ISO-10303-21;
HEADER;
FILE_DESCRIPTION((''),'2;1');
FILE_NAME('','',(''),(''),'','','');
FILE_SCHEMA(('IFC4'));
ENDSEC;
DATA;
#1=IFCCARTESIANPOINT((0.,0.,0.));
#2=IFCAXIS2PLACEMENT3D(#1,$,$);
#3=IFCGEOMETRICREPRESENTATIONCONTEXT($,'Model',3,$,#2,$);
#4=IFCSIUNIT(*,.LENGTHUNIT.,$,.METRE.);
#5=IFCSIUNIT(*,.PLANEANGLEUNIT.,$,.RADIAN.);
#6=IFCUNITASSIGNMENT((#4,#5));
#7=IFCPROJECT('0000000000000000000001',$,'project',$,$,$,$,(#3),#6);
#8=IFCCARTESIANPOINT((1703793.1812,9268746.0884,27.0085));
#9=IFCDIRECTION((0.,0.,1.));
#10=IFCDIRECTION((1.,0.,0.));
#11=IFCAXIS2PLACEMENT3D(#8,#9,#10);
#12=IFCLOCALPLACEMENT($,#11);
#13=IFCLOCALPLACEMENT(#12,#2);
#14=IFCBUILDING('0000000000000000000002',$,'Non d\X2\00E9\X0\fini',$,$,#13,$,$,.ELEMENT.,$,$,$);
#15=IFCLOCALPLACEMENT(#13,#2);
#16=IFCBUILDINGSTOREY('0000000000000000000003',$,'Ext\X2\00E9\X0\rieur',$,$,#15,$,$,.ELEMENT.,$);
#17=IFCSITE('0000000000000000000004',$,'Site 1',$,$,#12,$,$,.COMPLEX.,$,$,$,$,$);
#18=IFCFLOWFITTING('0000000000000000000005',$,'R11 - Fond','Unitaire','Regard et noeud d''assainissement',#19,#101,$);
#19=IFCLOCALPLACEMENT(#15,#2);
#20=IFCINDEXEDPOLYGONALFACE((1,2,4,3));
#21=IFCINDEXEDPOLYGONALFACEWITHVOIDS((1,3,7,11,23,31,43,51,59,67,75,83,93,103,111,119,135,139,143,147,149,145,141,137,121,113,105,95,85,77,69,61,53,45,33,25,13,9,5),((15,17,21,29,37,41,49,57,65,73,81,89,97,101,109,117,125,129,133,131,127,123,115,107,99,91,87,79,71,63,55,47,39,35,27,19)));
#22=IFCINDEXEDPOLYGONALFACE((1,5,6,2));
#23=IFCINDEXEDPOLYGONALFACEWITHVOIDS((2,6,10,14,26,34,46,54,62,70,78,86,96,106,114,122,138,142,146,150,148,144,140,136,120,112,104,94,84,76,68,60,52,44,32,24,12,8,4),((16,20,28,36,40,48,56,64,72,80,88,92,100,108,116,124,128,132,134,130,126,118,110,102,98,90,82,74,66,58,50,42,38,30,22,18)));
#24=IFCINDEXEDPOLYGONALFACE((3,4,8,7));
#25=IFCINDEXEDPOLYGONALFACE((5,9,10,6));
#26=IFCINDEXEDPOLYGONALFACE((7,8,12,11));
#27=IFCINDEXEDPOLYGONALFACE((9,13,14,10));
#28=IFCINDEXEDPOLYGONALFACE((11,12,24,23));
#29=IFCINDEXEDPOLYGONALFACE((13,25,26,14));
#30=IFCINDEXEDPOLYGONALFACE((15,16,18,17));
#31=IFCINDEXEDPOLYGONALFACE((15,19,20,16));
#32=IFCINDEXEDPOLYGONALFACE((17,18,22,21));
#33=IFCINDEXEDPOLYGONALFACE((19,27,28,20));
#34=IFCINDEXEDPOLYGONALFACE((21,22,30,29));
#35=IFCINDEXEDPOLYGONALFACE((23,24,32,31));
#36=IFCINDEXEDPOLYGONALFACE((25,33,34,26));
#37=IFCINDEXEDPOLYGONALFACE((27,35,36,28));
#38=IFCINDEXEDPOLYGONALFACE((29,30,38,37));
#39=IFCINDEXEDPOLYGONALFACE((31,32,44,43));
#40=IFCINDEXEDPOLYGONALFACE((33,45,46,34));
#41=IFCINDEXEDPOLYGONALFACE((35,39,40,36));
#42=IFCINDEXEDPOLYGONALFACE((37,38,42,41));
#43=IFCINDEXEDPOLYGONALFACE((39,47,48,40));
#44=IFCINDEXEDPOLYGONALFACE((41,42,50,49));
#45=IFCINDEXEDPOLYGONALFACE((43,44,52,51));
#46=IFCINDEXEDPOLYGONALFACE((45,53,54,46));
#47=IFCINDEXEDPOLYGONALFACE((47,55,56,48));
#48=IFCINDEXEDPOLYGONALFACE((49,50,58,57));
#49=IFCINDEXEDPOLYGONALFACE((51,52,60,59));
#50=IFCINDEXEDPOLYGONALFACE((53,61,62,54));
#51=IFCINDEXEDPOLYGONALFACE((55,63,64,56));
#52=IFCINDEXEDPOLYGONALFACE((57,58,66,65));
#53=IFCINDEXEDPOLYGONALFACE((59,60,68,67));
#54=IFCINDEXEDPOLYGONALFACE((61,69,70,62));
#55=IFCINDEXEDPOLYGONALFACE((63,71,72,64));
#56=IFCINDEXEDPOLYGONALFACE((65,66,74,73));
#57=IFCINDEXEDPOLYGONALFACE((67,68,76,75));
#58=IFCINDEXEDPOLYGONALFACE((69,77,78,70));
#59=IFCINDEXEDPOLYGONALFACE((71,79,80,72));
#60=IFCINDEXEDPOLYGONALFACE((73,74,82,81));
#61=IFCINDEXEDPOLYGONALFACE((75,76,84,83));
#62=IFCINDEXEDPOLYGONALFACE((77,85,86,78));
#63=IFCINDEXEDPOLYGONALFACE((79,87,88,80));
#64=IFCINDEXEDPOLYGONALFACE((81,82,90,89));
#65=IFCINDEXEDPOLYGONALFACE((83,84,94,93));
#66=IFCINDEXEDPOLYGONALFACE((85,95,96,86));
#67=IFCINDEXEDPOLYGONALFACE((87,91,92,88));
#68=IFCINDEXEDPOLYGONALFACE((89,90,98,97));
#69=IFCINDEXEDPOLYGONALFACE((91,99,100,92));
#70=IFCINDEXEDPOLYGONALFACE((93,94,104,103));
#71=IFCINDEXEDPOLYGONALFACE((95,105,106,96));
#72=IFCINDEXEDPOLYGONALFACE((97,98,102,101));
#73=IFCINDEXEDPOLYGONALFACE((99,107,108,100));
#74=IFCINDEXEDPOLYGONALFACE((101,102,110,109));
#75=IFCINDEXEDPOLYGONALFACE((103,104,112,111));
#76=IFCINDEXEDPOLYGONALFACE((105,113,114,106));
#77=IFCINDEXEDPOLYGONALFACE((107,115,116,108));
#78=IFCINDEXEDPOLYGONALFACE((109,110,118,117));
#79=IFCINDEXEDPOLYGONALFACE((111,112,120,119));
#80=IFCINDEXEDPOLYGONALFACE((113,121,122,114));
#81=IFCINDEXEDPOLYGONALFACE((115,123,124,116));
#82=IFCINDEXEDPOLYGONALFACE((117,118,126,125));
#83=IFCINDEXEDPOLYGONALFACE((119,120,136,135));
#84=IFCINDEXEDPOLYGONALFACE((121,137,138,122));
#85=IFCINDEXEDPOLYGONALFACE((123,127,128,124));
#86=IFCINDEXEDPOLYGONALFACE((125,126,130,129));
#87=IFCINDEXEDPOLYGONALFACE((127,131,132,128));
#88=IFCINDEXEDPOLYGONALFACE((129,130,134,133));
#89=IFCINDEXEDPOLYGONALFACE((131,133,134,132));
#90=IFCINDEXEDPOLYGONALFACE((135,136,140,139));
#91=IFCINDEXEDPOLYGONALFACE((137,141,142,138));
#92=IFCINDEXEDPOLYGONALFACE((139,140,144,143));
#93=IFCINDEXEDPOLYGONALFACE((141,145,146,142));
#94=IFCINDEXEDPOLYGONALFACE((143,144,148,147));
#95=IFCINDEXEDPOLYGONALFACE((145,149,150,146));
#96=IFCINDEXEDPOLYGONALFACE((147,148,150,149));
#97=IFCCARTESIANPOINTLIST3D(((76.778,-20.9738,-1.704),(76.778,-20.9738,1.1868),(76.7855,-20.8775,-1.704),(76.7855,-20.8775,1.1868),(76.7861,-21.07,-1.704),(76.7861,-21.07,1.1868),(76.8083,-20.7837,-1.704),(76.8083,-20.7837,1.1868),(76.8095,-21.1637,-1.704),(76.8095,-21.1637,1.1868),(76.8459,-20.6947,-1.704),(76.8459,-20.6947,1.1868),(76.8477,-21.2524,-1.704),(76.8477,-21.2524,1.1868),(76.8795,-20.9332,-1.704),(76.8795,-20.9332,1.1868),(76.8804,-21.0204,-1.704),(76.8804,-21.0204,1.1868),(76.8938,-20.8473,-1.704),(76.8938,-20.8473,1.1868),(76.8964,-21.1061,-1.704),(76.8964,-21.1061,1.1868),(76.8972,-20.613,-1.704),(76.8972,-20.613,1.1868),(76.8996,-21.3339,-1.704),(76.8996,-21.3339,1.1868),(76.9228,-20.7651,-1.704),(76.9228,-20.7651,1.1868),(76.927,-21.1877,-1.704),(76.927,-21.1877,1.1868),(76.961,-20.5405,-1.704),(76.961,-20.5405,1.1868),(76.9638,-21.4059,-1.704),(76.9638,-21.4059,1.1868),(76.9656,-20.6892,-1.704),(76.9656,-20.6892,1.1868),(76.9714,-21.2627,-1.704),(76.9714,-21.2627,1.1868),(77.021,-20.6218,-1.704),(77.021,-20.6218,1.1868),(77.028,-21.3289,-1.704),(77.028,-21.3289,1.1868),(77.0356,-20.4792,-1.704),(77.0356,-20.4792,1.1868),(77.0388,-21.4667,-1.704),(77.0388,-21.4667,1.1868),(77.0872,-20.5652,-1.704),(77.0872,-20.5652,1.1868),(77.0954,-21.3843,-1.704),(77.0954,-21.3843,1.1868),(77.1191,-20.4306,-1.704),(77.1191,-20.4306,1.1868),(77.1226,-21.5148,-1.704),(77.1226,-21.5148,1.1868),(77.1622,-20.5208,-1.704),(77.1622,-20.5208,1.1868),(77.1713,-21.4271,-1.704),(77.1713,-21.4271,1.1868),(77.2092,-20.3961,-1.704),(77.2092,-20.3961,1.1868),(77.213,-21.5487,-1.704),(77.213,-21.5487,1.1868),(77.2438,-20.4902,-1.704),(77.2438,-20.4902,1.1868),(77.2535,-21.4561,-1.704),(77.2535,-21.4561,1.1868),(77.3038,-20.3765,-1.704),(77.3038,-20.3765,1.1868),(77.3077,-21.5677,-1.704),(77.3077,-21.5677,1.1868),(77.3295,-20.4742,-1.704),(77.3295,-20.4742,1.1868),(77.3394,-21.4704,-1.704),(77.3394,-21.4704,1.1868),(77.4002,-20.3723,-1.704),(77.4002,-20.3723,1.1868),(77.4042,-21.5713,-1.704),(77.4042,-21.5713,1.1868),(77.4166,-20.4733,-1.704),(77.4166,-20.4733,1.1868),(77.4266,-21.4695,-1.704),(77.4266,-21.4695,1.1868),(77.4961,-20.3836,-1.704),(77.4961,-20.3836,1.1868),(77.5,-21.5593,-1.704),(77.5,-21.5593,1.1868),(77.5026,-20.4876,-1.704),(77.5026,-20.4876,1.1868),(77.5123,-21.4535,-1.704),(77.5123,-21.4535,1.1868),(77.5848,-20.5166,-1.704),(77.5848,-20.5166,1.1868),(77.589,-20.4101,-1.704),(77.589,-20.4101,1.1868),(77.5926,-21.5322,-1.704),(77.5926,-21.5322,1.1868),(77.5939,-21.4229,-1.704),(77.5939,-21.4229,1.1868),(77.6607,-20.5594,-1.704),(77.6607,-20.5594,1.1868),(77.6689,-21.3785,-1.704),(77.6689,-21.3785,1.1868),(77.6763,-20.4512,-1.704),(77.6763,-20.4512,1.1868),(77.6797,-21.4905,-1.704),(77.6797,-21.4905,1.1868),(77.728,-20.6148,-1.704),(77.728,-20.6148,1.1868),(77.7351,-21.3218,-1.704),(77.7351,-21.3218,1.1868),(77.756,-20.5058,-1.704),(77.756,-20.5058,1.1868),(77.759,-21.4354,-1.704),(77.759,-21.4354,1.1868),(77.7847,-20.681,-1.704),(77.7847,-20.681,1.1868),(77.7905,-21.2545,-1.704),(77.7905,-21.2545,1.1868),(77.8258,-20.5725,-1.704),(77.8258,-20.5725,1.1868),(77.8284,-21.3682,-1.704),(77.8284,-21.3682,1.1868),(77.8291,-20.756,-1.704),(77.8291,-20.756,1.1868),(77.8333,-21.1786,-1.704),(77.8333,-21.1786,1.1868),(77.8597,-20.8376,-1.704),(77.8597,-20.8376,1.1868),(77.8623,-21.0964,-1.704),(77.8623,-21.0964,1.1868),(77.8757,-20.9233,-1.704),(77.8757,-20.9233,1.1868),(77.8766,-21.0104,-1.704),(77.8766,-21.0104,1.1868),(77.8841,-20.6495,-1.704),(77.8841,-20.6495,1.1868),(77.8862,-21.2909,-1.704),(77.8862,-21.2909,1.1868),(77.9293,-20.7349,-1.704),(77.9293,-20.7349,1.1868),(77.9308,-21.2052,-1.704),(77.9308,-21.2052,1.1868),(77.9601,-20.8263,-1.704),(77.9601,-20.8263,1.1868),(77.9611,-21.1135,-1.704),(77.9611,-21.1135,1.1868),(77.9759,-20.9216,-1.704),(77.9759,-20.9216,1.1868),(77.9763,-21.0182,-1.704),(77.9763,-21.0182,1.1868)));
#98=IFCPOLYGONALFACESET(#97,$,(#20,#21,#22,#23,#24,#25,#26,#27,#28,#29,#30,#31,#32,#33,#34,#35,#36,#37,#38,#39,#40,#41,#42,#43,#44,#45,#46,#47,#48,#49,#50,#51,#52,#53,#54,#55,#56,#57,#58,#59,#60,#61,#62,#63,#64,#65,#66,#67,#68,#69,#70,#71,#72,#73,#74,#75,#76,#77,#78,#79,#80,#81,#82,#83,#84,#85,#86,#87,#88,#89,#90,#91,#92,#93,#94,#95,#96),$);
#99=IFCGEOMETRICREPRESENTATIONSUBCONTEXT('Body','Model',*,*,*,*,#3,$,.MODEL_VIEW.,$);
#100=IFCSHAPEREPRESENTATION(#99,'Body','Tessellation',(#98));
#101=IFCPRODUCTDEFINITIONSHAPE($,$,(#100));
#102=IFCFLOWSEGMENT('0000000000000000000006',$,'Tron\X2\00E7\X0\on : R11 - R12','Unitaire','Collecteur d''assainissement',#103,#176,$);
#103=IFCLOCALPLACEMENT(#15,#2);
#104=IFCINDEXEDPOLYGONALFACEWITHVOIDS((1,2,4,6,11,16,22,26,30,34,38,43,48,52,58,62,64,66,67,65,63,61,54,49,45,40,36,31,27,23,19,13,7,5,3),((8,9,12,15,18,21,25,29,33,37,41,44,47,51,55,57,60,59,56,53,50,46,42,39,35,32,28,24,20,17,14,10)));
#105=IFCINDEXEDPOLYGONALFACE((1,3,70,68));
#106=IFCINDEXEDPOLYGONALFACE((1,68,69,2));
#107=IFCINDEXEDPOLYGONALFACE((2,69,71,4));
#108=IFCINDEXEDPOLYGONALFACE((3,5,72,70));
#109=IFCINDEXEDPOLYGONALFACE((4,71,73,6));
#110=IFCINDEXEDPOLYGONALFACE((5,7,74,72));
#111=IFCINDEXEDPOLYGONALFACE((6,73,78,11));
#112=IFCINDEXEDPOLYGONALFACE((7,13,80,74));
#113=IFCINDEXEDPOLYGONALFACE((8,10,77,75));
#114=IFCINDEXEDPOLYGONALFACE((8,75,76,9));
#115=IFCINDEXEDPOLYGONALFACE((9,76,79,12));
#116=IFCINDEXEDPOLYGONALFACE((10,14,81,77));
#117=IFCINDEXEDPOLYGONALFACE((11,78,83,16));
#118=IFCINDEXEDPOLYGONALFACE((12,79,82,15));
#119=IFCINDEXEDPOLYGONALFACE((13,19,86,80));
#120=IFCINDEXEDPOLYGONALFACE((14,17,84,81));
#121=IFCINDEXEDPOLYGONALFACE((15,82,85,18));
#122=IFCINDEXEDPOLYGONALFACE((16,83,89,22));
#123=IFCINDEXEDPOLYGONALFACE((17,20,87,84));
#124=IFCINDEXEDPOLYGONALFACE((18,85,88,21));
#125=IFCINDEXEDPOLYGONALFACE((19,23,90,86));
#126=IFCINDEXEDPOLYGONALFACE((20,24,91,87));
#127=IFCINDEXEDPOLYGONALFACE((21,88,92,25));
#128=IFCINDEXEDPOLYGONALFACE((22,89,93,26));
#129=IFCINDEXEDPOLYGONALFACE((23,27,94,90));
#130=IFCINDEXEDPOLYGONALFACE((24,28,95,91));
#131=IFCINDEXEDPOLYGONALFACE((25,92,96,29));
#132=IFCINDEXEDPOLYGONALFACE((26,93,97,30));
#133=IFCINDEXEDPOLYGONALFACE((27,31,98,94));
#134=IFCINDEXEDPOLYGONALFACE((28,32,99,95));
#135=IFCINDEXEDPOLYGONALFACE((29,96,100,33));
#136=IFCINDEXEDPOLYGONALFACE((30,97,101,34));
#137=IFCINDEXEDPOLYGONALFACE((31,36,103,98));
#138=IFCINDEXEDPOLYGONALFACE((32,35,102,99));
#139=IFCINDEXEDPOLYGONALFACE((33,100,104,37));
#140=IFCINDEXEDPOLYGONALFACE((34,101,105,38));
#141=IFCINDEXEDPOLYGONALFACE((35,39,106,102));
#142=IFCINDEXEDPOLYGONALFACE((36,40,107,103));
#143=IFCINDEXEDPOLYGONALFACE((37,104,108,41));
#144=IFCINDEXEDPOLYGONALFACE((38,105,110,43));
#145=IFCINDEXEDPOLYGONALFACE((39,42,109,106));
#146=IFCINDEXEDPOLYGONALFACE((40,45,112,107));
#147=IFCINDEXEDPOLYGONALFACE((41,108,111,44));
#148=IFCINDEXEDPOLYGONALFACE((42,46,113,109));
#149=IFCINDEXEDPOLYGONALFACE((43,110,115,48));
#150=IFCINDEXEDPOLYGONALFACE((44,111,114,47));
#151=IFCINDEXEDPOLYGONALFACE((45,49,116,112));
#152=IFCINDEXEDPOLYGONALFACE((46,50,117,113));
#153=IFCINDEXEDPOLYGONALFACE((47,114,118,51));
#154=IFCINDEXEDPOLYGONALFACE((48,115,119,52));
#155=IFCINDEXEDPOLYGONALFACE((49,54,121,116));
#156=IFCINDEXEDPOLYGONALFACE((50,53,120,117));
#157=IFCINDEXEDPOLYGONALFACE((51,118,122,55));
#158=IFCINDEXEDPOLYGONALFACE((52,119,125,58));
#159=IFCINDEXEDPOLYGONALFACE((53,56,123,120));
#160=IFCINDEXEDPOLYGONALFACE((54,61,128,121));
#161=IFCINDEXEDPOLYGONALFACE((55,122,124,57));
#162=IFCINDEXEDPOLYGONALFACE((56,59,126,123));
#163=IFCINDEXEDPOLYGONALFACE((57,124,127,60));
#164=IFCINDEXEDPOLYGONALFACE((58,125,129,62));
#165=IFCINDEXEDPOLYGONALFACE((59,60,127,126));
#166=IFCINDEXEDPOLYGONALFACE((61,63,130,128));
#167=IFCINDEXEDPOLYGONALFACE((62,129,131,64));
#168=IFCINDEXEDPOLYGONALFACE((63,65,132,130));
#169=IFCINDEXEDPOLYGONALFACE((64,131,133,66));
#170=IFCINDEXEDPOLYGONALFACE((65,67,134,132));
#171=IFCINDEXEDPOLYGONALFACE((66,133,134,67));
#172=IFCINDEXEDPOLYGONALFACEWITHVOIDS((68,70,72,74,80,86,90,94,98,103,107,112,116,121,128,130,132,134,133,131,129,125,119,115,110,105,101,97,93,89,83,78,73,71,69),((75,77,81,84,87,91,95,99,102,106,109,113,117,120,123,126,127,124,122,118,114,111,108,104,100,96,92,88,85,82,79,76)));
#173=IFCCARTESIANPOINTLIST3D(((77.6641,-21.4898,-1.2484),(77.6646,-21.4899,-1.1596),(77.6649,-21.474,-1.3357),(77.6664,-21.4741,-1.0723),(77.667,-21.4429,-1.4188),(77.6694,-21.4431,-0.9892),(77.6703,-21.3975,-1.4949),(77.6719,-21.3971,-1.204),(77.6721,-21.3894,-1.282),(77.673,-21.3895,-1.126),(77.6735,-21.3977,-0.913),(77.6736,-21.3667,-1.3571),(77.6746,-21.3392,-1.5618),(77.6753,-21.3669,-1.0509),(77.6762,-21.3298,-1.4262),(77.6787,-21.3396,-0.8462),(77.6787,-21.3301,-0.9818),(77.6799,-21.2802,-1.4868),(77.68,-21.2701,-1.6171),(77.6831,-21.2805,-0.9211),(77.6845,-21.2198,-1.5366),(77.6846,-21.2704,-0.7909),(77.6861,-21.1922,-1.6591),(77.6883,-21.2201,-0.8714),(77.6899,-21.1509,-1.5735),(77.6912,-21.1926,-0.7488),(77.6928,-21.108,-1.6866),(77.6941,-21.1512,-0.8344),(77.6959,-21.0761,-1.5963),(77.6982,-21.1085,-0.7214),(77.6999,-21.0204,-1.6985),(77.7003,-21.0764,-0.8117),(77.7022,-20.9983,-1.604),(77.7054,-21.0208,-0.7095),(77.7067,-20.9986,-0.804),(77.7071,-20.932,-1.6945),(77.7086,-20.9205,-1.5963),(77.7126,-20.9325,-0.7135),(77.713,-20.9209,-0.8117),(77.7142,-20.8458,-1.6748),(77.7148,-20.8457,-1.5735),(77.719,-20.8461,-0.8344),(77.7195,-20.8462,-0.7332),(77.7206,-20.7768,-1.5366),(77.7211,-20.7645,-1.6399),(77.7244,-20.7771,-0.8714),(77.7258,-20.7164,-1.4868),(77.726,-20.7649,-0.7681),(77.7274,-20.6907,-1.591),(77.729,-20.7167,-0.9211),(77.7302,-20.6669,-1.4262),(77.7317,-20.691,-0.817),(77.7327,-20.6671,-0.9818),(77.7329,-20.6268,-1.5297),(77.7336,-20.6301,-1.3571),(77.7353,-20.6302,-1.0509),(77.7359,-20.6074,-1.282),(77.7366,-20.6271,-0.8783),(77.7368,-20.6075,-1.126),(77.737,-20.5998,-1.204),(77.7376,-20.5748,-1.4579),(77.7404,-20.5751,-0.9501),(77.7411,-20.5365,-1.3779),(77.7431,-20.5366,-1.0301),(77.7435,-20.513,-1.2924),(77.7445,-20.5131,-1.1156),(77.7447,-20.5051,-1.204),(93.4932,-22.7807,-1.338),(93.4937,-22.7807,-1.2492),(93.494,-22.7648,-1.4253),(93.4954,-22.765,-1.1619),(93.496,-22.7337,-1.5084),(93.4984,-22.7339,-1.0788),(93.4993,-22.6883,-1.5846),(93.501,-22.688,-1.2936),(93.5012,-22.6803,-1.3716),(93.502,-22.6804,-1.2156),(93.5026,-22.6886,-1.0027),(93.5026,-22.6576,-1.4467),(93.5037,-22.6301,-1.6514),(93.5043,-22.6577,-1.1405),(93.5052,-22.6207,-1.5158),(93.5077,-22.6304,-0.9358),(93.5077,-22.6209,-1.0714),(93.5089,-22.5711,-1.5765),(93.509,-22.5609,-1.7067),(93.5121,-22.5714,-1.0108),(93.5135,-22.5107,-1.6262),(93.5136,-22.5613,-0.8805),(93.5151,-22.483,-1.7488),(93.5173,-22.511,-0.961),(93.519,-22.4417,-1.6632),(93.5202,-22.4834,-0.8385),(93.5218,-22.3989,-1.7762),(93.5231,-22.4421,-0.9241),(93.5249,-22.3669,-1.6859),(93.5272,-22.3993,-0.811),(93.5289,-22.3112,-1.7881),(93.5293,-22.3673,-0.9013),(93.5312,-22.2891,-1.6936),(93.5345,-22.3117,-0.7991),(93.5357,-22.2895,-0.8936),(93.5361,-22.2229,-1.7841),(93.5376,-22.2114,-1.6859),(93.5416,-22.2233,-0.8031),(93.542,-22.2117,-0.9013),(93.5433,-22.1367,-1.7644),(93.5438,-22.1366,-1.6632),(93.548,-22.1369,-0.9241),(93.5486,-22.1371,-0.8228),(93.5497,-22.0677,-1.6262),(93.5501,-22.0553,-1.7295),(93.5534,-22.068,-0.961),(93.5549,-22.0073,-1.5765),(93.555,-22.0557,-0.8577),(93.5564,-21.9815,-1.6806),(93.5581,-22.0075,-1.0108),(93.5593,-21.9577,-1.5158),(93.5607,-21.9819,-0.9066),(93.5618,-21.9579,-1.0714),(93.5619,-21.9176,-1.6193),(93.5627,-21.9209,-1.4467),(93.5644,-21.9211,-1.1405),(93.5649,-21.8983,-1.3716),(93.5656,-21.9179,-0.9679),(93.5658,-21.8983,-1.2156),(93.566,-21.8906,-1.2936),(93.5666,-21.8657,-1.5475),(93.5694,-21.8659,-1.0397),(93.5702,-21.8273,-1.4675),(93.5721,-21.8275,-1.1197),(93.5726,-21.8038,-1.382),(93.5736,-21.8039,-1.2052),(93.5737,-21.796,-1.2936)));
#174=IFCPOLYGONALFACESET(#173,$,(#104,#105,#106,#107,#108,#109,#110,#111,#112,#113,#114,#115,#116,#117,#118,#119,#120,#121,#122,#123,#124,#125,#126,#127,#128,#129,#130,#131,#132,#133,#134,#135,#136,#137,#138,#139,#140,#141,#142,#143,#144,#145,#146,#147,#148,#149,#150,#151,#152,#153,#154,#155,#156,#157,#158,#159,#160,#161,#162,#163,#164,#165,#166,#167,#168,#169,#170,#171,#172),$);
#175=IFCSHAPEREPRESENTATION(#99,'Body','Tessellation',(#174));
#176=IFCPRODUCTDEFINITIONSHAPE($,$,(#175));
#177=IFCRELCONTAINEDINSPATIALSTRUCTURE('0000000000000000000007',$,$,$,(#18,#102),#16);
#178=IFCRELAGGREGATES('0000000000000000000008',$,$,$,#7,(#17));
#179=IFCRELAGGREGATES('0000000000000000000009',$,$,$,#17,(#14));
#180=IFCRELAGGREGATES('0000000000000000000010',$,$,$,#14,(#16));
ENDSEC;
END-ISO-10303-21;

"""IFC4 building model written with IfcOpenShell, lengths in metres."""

from ifc_helpers import new_model, si_unit, frame, origin, origin_2d, place, context, subcontext, project, spatial, hollow_circle, extrude, element, save


model = new_model("IFC4")

# Units and contexts
model_context = context("Model", 3, world=origin())
body_context = subcontext(model_context, "Body", "Model", "MODEL_VIEW")
ifc_project = project(units=[si_unit("LENGTHUNIT", "METRE"), si_unit("PLANEANGLEUNIT", "RADIAN")], contexts=[model_context])

# Site, building, storey
site_placement = place(None, frame((1703793.1812, 9268746.0884, 27.0085), z_axis=(0.0, 0.0, 1.0), x_axis=(1.0, 0.0, 0.0)))
site = spatial("IfcSite", under=ifc_project, at=site_placement, Name="Site 1", CompositionType="COMPLEX")
building_placement = place(site_placement, origin())
building = spatial("IfcBuilding", under=site, at=building_placement, Name="Non défini", CompositionType="ELEMENT")
storey_placement = place(building_placement, origin())
storey = spatial("IfcBuildingStorey", under=building, at=storey_placement, Name="Extérieur", CompositionType="ELEMENT")

# Flow fitting
flow_fitting_1_placement = place(storey_placement, origin())
element("IfcFlowFitting", 1, at=flow_fitting_1_placement, inside=storey, Name="R11 - Fond", Description="Unitaire", ObjectType="Regard et noeud d'assainissement", context=body_context, shape_type="SweptSolid", body=[
    extrude(hollow_circle(Radius=0.6, WallThickness=0.1, at=origin_2d()), frame((77.378, -20.9718, -1.704), z_axis=(0.0, 0.0, 1.0), x_axis=(0.997015, -0.077207, 0.0)), (0.0, 0.0, 1.0), 2.8908),
])

# Flow segment
flow_segment_1_placement = place(storey_placement, origin())
element("IfcFlowSegment", 2, at=flow_segment_1_placement, inside=storey, Name="Tronçon : R11 - R12", Description="Unitaire", ObjectType="Collecteur d'assainissement", context=body_context, shape_type="SweptSolid", body=[
    extrude(hollow_circle(Radius=0.495, WallThickness=0.095, at=origin_2d()), frame((77.7045, -20.9985, -1.204), z_axis=(0.996675, -0.081279, -0.005643), x_axis=(0.08128, 0.996691, 0.0)), (0.0, 0.0, 1.0), 15.8818),
])

save(model, "model.ifc")
